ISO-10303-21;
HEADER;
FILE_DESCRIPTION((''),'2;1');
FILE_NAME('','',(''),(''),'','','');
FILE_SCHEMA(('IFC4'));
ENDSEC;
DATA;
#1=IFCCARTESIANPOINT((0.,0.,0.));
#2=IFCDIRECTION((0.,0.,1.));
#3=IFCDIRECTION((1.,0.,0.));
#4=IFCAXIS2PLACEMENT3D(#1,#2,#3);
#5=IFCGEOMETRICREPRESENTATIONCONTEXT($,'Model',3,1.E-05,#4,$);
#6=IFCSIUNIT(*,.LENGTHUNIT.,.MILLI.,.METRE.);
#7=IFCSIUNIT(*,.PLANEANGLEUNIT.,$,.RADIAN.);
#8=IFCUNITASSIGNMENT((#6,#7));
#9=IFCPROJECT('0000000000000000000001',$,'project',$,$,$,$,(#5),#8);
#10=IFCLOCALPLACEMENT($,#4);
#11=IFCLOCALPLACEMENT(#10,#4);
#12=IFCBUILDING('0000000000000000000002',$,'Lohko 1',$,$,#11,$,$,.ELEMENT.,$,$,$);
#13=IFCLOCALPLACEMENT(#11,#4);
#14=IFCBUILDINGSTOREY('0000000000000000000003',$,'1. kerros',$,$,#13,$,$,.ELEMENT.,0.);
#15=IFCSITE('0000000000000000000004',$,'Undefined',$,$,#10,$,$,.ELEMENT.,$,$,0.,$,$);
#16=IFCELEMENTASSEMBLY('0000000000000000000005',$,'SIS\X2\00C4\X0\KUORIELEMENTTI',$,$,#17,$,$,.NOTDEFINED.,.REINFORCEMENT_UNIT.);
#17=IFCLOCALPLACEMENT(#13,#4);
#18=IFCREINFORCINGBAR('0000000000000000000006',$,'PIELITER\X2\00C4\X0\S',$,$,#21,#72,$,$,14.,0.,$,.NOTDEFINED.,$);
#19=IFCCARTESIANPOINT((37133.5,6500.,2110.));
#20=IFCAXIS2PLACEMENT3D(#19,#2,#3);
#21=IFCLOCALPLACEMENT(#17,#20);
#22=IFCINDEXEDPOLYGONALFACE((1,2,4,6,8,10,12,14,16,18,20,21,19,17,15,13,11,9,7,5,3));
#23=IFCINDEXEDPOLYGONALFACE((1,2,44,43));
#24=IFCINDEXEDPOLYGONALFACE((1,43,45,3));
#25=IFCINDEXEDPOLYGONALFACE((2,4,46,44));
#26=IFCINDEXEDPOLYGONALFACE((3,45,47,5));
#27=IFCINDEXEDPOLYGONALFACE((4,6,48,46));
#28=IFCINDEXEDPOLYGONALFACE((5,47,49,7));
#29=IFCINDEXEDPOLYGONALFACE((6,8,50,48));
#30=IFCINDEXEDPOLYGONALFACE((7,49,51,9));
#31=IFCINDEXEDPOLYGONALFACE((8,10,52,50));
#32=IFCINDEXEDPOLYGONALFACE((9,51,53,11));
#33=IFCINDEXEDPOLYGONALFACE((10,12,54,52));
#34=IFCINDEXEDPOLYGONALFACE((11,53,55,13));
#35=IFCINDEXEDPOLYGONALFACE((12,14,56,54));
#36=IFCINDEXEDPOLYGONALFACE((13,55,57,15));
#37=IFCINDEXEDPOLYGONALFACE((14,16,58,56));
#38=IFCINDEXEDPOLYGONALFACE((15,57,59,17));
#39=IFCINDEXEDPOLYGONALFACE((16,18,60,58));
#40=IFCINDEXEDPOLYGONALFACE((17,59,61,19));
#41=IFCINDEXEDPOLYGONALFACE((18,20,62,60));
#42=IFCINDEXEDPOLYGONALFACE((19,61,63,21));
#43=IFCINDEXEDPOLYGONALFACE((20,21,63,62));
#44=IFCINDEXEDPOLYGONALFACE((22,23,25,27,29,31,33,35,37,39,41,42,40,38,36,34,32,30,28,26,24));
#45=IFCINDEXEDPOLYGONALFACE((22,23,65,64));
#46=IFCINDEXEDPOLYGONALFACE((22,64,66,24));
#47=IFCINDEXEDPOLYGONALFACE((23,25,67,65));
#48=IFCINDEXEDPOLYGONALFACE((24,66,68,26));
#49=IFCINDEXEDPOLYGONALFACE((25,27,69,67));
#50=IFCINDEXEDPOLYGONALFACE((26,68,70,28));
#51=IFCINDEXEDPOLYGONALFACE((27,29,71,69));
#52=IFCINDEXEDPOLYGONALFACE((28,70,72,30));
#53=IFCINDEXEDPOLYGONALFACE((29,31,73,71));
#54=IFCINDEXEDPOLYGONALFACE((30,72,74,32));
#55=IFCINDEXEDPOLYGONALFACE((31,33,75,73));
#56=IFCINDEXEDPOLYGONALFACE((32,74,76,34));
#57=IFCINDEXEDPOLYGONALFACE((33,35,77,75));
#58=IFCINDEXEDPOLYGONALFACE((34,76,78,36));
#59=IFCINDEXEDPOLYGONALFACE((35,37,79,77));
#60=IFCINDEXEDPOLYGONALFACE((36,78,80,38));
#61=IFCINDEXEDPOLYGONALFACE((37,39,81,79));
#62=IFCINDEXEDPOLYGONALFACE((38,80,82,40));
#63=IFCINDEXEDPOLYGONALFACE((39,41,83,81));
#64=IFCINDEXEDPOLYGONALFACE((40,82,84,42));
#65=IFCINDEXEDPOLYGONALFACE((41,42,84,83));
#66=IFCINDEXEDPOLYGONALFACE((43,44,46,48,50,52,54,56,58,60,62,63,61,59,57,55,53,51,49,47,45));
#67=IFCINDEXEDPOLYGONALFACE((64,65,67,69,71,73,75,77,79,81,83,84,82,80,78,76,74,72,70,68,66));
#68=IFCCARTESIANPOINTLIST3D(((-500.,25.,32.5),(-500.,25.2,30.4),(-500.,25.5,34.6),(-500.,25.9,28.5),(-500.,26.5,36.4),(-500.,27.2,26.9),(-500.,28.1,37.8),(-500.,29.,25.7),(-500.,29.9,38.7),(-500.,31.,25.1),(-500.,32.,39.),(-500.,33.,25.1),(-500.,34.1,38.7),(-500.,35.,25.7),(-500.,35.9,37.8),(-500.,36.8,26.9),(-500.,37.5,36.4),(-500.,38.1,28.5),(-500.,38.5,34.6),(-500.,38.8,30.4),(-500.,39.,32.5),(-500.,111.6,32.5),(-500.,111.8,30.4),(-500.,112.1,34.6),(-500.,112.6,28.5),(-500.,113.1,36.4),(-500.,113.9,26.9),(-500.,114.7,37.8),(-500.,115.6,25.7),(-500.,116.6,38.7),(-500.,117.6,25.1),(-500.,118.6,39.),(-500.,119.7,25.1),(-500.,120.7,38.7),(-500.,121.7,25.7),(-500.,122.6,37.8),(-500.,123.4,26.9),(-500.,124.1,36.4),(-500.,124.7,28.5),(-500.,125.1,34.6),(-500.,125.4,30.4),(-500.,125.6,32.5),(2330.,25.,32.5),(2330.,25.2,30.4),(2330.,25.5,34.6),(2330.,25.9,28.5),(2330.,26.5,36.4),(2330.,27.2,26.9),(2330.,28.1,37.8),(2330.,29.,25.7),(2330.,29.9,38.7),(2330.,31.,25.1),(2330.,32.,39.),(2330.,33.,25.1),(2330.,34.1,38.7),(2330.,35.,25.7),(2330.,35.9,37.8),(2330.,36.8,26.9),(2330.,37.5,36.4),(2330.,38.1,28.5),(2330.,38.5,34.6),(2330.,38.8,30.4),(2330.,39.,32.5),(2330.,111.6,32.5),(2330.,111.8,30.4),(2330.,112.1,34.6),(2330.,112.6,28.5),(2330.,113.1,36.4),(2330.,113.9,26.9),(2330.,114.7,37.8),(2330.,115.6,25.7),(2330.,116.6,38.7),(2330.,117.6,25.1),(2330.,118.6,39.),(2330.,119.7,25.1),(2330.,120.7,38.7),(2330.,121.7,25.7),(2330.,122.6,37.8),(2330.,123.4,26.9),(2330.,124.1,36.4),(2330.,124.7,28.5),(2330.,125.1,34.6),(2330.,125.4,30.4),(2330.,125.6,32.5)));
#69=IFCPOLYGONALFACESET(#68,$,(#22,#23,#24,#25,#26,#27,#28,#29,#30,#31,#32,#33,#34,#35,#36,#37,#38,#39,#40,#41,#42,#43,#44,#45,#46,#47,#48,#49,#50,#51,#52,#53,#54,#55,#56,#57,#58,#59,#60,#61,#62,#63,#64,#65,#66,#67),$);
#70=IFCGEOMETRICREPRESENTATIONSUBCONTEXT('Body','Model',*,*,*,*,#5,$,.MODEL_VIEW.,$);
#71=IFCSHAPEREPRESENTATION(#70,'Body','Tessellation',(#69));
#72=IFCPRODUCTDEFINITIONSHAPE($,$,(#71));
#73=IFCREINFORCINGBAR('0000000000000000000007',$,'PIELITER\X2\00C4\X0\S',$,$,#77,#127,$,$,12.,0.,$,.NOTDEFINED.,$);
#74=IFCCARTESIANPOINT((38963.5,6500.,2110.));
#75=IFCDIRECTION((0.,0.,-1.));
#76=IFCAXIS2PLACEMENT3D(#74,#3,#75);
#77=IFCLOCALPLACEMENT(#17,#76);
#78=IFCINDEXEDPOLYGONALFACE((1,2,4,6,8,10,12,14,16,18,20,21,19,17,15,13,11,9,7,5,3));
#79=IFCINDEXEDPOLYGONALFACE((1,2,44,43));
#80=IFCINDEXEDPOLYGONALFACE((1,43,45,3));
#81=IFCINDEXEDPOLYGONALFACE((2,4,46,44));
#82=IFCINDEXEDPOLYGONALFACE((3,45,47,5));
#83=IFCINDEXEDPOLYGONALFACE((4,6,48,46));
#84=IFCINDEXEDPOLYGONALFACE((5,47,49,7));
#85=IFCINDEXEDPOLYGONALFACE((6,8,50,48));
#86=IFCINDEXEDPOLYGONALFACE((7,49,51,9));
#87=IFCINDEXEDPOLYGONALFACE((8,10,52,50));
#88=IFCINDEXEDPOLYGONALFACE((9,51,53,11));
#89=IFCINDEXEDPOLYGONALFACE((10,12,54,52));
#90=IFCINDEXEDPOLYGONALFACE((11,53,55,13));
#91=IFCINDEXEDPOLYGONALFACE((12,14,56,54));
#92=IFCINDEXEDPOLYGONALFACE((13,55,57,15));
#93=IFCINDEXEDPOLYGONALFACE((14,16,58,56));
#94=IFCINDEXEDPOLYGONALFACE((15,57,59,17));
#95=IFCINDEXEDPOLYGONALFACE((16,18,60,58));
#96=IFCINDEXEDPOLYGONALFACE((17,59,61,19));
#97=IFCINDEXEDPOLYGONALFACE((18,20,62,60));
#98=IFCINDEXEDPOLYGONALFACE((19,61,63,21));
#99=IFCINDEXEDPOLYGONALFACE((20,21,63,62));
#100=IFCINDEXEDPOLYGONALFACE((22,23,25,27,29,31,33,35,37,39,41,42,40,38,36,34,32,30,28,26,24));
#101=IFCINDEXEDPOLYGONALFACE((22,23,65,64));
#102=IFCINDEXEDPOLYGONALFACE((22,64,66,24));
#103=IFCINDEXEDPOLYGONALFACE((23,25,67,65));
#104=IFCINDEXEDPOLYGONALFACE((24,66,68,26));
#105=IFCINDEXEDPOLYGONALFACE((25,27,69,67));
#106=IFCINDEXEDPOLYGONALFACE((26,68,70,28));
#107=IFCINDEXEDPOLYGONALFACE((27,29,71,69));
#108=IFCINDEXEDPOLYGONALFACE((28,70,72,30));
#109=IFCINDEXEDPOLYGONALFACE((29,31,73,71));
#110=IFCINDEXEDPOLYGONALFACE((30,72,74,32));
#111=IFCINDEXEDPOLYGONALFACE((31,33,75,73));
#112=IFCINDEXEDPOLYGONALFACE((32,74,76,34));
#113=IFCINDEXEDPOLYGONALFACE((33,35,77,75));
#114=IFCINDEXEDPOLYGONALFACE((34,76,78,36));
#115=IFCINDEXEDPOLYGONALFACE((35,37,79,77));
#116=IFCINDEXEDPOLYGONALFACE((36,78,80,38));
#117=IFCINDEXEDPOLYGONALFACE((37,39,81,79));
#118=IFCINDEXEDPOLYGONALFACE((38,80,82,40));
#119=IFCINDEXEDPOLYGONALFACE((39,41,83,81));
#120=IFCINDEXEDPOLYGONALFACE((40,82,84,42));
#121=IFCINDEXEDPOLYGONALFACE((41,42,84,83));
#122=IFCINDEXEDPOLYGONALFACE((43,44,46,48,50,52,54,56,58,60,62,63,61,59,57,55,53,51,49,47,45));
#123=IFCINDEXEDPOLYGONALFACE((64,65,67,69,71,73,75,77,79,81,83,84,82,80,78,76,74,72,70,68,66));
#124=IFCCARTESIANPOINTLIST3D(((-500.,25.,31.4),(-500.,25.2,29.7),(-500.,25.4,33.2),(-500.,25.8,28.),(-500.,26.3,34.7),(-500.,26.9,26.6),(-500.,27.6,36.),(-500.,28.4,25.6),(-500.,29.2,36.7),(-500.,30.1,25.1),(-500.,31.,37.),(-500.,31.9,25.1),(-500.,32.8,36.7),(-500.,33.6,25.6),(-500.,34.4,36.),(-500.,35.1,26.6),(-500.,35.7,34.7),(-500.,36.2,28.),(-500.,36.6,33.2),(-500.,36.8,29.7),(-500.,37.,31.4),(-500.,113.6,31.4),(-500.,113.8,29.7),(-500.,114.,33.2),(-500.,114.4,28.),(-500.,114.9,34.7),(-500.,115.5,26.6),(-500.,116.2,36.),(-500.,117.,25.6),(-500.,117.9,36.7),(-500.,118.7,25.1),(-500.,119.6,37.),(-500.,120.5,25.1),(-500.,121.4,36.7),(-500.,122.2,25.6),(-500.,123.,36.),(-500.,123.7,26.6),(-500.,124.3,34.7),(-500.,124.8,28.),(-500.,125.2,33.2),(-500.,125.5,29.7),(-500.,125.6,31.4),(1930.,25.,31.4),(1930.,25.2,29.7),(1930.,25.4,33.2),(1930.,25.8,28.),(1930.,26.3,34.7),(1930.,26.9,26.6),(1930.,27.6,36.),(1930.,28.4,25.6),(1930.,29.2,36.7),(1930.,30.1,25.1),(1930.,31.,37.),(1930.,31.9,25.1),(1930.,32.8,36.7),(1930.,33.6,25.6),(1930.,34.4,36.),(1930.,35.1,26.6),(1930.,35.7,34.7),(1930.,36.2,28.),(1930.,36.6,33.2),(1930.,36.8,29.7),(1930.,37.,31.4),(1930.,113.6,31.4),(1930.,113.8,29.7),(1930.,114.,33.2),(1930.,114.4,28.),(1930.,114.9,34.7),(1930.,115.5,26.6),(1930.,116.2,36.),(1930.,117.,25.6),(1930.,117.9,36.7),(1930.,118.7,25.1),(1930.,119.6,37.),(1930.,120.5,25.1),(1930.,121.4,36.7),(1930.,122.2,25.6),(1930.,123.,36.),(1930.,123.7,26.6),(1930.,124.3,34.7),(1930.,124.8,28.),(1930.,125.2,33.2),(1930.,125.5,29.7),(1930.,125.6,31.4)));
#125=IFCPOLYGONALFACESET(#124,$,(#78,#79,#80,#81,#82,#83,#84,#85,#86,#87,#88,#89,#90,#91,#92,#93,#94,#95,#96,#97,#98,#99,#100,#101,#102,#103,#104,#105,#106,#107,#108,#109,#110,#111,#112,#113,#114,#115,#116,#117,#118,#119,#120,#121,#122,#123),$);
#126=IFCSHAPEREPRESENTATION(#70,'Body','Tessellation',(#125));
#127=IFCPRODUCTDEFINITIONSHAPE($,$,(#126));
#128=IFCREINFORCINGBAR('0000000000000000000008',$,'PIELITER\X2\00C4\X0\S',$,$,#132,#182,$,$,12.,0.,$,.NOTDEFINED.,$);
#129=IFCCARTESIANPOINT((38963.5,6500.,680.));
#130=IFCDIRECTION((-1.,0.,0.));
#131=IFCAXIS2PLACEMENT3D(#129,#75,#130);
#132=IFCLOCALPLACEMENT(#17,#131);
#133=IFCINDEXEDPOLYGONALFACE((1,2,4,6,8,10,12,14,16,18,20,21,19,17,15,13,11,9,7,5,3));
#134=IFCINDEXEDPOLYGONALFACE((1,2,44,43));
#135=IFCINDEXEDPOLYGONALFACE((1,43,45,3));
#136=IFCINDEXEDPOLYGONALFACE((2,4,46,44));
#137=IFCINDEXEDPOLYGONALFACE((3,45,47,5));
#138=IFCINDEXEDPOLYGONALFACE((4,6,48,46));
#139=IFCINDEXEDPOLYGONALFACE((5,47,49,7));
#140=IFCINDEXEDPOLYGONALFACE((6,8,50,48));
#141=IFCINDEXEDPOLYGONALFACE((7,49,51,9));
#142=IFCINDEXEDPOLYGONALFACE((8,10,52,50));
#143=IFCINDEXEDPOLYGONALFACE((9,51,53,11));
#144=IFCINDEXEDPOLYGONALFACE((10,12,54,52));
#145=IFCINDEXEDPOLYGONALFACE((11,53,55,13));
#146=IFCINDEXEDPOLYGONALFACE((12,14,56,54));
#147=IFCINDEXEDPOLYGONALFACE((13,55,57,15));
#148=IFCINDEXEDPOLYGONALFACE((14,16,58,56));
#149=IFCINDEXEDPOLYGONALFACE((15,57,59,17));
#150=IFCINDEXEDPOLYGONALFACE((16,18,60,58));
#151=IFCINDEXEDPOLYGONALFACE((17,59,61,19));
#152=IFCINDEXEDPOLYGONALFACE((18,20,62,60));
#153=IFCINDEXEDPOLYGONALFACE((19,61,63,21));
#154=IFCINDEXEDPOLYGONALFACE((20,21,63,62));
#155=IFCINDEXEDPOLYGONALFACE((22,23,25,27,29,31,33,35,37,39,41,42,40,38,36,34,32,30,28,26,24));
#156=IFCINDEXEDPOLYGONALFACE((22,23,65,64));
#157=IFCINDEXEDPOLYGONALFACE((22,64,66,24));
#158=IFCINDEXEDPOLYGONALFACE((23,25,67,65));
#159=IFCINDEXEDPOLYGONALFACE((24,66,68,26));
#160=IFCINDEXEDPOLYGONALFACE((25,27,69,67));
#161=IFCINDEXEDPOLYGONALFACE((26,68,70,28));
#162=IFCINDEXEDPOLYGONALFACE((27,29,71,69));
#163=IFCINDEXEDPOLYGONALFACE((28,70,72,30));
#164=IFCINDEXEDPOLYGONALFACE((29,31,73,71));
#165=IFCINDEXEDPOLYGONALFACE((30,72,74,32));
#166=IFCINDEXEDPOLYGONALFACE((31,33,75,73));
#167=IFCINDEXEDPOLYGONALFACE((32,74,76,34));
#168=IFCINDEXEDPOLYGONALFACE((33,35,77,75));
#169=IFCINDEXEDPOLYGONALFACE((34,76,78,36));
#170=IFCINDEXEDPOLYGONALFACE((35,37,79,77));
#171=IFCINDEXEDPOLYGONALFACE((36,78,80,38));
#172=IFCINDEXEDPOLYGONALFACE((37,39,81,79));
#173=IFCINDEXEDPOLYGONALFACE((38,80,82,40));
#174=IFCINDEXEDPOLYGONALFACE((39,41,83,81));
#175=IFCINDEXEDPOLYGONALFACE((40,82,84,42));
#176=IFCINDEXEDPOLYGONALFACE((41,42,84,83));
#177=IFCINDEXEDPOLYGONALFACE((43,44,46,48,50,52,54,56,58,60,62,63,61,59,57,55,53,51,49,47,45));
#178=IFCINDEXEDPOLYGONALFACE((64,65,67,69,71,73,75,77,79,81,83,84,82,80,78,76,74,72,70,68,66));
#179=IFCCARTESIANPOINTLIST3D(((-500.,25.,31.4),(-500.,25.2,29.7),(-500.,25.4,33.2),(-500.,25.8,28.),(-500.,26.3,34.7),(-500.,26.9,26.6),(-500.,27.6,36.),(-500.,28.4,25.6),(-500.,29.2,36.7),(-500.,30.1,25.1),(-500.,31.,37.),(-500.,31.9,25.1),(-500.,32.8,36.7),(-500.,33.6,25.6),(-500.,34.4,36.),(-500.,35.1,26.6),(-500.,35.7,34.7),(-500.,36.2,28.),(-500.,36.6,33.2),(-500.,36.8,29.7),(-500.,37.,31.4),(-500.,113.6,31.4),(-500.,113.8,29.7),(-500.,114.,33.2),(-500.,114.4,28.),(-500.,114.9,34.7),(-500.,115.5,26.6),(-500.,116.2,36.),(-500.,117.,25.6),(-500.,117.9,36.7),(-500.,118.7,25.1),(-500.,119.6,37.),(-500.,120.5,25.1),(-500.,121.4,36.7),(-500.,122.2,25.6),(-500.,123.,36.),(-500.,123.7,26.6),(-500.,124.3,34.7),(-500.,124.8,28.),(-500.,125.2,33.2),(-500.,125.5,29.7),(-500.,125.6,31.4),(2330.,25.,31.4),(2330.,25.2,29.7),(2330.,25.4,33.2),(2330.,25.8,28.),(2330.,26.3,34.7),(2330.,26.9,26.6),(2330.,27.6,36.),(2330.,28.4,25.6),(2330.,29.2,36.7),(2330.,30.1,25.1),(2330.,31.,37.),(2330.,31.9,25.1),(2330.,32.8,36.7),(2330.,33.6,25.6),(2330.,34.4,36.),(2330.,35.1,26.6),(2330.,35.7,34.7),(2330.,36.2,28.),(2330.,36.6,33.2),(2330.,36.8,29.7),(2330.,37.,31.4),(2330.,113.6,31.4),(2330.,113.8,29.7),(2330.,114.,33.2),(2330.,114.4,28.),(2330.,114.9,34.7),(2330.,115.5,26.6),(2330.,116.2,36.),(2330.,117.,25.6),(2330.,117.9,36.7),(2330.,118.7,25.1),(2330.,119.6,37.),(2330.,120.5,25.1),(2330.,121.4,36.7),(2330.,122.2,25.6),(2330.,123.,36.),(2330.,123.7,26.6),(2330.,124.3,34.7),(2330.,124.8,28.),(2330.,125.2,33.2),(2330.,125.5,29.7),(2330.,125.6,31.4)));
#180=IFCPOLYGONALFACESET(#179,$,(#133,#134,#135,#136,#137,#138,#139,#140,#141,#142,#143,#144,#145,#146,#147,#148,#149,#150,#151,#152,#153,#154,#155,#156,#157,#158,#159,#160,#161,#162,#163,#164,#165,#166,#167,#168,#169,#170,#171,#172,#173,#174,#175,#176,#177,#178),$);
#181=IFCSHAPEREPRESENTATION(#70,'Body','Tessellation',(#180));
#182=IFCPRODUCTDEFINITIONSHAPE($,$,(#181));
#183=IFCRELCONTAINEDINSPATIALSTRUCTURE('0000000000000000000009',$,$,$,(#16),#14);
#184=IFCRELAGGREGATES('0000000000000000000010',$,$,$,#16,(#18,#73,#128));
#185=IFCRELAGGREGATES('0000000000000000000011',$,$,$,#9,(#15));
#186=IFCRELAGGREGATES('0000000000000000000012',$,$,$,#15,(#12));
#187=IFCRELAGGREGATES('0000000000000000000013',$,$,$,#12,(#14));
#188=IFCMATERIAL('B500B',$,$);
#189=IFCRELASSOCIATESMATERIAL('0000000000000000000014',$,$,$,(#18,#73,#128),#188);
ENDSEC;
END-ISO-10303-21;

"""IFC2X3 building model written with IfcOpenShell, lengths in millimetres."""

from ifc_helpers import new_model, entity, si_unit, frame, origin_with_axes, place, context, subcontext, project, spatial, source, transform, mapped, material, element, aggregate, save


model = new_model("IFC2X3")

# Units and contexts
model_context = context("Model", 3, precision=1e-05, world=origin_with_axes())
body_context = subcontext(model_context, "Body", "Model", "MODEL_VIEW")
ifc_project = project(units=[si_unit("LENGTHUNIT", "METRE", prefix="MILLI"), si_unit("PLANEANGLEUNIT", "RADIAN")], contexts=[model_context])

# Site, building, storey
site_placement = place(None, origin_with_axes())
site = spatial("IfcSite", under=ifc_project, at=site_placement, Name="Undefined", CompositionType="ELEMENT", RefElevation=0.0)
building_placement = place(site_placement, origin_with_axes())
building = spatial("IfcBuilding", under=site, at=building_placement, Name="Lohko 1", CompositionType="ELEMENT")
storey_placement = place(building_placement, origin_with_axes())
storey = spatial("IfcBuildingStorey", under=building, at=storey_placement, Name="1. kerros", CompositionType="ELEMENT", Elevation=0.0)

# Element assembly, reinforcing bars
assembly_placement = place(storey_placement, origin_with_axes())
assembly = element("IfcElementAssembly", 1, at=assembly_placement, inside=storey, Name="SISÄKUORIELEMENTTI", AssemblyPlace="NOTDEFINED", PredefinedType="REINFORCEMENT_UNIT")
ifc_material = material(Name="B500B")
shared_shape_1 = source(origin_with_axes(), body_context, "Body", "AdvancedSweptSolid", [
    entity("IfcSweptDiskSolid", entity("IfcTrimmedCurve", entity("IfcLine", entity("IfcCartesianPoint", [0.0, 0.0, 0.0]), entity("IfcVector", entity("IfcDirection", [1.0, 0.0, 0.0]), 1.0)), [entity("IfcParameterValue", 0.0)], [entity("IfcParameterValue", 2830.0)], True, "PARAMETER"), 7.0, None, 0.0, 2830.0),
])
shared_shape_2 = source(origin_with_axes(), body_context, "Body", "AdvancedSweptSolid", [
    entity("IfcSweptDiskSolid", entity("IfcTrimmedCurve", entity("IfcLine", entity("IfcCartesianPoint", [0.0, 0.0, 0.0]), entity("IfcVector", entity("IfcDirection", [1.0, 0.0, 0.0]), 1.0)), [entity("IfcParameterValue", 0.0)], [entity("IfcParameterValue", 2830.0)], True, "PARAMETER"), 7.0, None, 0.0, 2830.0),
])
reinforcing_bar_1_placement = place(assembly_placement, frame((37133.5, 6500.0, 2110.0), z_axis=(0.0, 0.0, 1.0), x_axis=(1.0, 0.0, 0.0)))
reinforcing_bar_1 = element("IfcReinforcingBar", 2, at=reinforcing_bar_1_placement, material=ifc_material, Name="PIELITERÄS", BarRole="NOTDEFINED", CrossSectionArea=0.0, NominalDiameter=14.0, context=body_context, shape_type="MappedRepresentation", body=[
    mapped(shared_shape_1, transform((-500.0, 32.0, 32.0))),
    mapped(shared_shape_2, transform((-500.0, 118.6, 32.0))),
])
shared_shape_3 = source(origin_with_axes(), body_context, "Body", "AdvancedSweptSolid", [
    entity("IfcSweptDiskSolid", entity("IfcTrimmedCurve", entity("IfcLine", entity("IfcCartesianPoint", [0.0, 0.0, 0.0]), entity("IfcVector", entity("IfcDirection", [1.0, 0.0, 0.0]), 1.0)), [entity("IfcParameterValue", 0.0)], [entity("IfcParameterValue", 2430.0)], True, "PARAMETER"), 6.0, None, 0.0, 2430.0),
])
shared_shape_4 = source(origin_with_axes(), body_context, "Body", "AdvancedSweptSolid", [
    entity("IfcSweptDiskSolid", entity("IfcTrimmedCurve", entity("IfcLine", entity("IfcCartesianPoint", [0.0, 0.0, 0.0]), entity("IfcVector", entity("IfcDirection", [1.0, 0.0, 0.0]), 1.0)), [entity("IfcParameterValue", 0.0)], [entity("IfcParameterValue", 2430.0)], True, "PARAMETER"), 6.0, None, 0.0, 2430.0),
])
reinforcing_bar_2_placement = place(assembly_placement, frame((38963.5, 6500.0, 2110.0), z_axis=(1.0, 0.0, 0.0), x_axis=(0.0, 0.0, -1.0)))
reinforcing_bar_2 = element("IfcReinforcingBar", 3, at=reinforcing_bar_2_placement, material=ifc_material, Name="PIELITERÄS", BarRole="NOTDEFINED", CrossSectionArea=0.0, NominalDiameter=12.0, context=body_context, shape_type="MappedRepresentation", body=[
    mapped(shared_shape_3, transform((-500.0, 31.0, 31.0))),
    mapped(shared_shape_4, transform((-500.0, 119.6, 31.0))),
])
shared_shape_5 = source(origin_with_axes(), body_context, "Body", "AdvancedSweptSolid", [
    entity("IfcSweptDiskSolid", entity("IfcTrimmedCurve", entity("IfcLine", entity("IfcCartesianPoint", [0.0, 0.0, 0.0]), entity("IfcVector", entity("IfcDirection", [1.0, 0.0, 0.0]), 1.0)), [entity("IfcParameterValue", 0.0)], [entity("IfcParameterValue", 2830.0)], True, "PARAMETER"), 6.0, None, 0.0, 2830.0),
])
shared_shape_6 = source(origin_with_axes(), body_context, "Body", "AdvancedSweptSolid", [
    entity("IfcSweptDiskSolid", entity("IfcTrimmedCurve", entity("IfcLine", entity("IfcCartesianPoint", [0.0, 0.0, 0.0]), entity("IfcVector", entity("IfcDirection", [1.0, 0.0, 0.0]), 1.0)), [entity("IfcParameterValue", 0.0)], [entity("IfcParameterValue", 2830.0)], True, "PARAMETER"), 6.0, None, 0.0, 2830.0),
])
reinforcing_bar_3_placement = place(assembly_placement, frame((38963.5, 6500.0, 680.0), z_axis=(0.0, 0.0, -1.0), x_axis=(-1.0, 0.0, 0.0)))
reinforcing_bar_3 = element("IfcReinforcingBar", 4, at=reinforcing_bar_3_placement, material=ifc_material, Name="PIELITERÄS", BarRole="NOTDEFINED", CrossSectionArea=0.0, NominalDiameter=12.0, context=body_context, shape_type="MappedRepresentation", body=[
    mapped(shared_shape_5, transform((-500.0, 31.0, 31.0))),
    mapped(shared_shape_6, transform((-500.0, 119.6, 31.0))),
])
aggregate(assembly, [reinforcing_bar_1, reinforcing_bar_2, reinforcing_bar_3])

save(model, "model.ifc")
